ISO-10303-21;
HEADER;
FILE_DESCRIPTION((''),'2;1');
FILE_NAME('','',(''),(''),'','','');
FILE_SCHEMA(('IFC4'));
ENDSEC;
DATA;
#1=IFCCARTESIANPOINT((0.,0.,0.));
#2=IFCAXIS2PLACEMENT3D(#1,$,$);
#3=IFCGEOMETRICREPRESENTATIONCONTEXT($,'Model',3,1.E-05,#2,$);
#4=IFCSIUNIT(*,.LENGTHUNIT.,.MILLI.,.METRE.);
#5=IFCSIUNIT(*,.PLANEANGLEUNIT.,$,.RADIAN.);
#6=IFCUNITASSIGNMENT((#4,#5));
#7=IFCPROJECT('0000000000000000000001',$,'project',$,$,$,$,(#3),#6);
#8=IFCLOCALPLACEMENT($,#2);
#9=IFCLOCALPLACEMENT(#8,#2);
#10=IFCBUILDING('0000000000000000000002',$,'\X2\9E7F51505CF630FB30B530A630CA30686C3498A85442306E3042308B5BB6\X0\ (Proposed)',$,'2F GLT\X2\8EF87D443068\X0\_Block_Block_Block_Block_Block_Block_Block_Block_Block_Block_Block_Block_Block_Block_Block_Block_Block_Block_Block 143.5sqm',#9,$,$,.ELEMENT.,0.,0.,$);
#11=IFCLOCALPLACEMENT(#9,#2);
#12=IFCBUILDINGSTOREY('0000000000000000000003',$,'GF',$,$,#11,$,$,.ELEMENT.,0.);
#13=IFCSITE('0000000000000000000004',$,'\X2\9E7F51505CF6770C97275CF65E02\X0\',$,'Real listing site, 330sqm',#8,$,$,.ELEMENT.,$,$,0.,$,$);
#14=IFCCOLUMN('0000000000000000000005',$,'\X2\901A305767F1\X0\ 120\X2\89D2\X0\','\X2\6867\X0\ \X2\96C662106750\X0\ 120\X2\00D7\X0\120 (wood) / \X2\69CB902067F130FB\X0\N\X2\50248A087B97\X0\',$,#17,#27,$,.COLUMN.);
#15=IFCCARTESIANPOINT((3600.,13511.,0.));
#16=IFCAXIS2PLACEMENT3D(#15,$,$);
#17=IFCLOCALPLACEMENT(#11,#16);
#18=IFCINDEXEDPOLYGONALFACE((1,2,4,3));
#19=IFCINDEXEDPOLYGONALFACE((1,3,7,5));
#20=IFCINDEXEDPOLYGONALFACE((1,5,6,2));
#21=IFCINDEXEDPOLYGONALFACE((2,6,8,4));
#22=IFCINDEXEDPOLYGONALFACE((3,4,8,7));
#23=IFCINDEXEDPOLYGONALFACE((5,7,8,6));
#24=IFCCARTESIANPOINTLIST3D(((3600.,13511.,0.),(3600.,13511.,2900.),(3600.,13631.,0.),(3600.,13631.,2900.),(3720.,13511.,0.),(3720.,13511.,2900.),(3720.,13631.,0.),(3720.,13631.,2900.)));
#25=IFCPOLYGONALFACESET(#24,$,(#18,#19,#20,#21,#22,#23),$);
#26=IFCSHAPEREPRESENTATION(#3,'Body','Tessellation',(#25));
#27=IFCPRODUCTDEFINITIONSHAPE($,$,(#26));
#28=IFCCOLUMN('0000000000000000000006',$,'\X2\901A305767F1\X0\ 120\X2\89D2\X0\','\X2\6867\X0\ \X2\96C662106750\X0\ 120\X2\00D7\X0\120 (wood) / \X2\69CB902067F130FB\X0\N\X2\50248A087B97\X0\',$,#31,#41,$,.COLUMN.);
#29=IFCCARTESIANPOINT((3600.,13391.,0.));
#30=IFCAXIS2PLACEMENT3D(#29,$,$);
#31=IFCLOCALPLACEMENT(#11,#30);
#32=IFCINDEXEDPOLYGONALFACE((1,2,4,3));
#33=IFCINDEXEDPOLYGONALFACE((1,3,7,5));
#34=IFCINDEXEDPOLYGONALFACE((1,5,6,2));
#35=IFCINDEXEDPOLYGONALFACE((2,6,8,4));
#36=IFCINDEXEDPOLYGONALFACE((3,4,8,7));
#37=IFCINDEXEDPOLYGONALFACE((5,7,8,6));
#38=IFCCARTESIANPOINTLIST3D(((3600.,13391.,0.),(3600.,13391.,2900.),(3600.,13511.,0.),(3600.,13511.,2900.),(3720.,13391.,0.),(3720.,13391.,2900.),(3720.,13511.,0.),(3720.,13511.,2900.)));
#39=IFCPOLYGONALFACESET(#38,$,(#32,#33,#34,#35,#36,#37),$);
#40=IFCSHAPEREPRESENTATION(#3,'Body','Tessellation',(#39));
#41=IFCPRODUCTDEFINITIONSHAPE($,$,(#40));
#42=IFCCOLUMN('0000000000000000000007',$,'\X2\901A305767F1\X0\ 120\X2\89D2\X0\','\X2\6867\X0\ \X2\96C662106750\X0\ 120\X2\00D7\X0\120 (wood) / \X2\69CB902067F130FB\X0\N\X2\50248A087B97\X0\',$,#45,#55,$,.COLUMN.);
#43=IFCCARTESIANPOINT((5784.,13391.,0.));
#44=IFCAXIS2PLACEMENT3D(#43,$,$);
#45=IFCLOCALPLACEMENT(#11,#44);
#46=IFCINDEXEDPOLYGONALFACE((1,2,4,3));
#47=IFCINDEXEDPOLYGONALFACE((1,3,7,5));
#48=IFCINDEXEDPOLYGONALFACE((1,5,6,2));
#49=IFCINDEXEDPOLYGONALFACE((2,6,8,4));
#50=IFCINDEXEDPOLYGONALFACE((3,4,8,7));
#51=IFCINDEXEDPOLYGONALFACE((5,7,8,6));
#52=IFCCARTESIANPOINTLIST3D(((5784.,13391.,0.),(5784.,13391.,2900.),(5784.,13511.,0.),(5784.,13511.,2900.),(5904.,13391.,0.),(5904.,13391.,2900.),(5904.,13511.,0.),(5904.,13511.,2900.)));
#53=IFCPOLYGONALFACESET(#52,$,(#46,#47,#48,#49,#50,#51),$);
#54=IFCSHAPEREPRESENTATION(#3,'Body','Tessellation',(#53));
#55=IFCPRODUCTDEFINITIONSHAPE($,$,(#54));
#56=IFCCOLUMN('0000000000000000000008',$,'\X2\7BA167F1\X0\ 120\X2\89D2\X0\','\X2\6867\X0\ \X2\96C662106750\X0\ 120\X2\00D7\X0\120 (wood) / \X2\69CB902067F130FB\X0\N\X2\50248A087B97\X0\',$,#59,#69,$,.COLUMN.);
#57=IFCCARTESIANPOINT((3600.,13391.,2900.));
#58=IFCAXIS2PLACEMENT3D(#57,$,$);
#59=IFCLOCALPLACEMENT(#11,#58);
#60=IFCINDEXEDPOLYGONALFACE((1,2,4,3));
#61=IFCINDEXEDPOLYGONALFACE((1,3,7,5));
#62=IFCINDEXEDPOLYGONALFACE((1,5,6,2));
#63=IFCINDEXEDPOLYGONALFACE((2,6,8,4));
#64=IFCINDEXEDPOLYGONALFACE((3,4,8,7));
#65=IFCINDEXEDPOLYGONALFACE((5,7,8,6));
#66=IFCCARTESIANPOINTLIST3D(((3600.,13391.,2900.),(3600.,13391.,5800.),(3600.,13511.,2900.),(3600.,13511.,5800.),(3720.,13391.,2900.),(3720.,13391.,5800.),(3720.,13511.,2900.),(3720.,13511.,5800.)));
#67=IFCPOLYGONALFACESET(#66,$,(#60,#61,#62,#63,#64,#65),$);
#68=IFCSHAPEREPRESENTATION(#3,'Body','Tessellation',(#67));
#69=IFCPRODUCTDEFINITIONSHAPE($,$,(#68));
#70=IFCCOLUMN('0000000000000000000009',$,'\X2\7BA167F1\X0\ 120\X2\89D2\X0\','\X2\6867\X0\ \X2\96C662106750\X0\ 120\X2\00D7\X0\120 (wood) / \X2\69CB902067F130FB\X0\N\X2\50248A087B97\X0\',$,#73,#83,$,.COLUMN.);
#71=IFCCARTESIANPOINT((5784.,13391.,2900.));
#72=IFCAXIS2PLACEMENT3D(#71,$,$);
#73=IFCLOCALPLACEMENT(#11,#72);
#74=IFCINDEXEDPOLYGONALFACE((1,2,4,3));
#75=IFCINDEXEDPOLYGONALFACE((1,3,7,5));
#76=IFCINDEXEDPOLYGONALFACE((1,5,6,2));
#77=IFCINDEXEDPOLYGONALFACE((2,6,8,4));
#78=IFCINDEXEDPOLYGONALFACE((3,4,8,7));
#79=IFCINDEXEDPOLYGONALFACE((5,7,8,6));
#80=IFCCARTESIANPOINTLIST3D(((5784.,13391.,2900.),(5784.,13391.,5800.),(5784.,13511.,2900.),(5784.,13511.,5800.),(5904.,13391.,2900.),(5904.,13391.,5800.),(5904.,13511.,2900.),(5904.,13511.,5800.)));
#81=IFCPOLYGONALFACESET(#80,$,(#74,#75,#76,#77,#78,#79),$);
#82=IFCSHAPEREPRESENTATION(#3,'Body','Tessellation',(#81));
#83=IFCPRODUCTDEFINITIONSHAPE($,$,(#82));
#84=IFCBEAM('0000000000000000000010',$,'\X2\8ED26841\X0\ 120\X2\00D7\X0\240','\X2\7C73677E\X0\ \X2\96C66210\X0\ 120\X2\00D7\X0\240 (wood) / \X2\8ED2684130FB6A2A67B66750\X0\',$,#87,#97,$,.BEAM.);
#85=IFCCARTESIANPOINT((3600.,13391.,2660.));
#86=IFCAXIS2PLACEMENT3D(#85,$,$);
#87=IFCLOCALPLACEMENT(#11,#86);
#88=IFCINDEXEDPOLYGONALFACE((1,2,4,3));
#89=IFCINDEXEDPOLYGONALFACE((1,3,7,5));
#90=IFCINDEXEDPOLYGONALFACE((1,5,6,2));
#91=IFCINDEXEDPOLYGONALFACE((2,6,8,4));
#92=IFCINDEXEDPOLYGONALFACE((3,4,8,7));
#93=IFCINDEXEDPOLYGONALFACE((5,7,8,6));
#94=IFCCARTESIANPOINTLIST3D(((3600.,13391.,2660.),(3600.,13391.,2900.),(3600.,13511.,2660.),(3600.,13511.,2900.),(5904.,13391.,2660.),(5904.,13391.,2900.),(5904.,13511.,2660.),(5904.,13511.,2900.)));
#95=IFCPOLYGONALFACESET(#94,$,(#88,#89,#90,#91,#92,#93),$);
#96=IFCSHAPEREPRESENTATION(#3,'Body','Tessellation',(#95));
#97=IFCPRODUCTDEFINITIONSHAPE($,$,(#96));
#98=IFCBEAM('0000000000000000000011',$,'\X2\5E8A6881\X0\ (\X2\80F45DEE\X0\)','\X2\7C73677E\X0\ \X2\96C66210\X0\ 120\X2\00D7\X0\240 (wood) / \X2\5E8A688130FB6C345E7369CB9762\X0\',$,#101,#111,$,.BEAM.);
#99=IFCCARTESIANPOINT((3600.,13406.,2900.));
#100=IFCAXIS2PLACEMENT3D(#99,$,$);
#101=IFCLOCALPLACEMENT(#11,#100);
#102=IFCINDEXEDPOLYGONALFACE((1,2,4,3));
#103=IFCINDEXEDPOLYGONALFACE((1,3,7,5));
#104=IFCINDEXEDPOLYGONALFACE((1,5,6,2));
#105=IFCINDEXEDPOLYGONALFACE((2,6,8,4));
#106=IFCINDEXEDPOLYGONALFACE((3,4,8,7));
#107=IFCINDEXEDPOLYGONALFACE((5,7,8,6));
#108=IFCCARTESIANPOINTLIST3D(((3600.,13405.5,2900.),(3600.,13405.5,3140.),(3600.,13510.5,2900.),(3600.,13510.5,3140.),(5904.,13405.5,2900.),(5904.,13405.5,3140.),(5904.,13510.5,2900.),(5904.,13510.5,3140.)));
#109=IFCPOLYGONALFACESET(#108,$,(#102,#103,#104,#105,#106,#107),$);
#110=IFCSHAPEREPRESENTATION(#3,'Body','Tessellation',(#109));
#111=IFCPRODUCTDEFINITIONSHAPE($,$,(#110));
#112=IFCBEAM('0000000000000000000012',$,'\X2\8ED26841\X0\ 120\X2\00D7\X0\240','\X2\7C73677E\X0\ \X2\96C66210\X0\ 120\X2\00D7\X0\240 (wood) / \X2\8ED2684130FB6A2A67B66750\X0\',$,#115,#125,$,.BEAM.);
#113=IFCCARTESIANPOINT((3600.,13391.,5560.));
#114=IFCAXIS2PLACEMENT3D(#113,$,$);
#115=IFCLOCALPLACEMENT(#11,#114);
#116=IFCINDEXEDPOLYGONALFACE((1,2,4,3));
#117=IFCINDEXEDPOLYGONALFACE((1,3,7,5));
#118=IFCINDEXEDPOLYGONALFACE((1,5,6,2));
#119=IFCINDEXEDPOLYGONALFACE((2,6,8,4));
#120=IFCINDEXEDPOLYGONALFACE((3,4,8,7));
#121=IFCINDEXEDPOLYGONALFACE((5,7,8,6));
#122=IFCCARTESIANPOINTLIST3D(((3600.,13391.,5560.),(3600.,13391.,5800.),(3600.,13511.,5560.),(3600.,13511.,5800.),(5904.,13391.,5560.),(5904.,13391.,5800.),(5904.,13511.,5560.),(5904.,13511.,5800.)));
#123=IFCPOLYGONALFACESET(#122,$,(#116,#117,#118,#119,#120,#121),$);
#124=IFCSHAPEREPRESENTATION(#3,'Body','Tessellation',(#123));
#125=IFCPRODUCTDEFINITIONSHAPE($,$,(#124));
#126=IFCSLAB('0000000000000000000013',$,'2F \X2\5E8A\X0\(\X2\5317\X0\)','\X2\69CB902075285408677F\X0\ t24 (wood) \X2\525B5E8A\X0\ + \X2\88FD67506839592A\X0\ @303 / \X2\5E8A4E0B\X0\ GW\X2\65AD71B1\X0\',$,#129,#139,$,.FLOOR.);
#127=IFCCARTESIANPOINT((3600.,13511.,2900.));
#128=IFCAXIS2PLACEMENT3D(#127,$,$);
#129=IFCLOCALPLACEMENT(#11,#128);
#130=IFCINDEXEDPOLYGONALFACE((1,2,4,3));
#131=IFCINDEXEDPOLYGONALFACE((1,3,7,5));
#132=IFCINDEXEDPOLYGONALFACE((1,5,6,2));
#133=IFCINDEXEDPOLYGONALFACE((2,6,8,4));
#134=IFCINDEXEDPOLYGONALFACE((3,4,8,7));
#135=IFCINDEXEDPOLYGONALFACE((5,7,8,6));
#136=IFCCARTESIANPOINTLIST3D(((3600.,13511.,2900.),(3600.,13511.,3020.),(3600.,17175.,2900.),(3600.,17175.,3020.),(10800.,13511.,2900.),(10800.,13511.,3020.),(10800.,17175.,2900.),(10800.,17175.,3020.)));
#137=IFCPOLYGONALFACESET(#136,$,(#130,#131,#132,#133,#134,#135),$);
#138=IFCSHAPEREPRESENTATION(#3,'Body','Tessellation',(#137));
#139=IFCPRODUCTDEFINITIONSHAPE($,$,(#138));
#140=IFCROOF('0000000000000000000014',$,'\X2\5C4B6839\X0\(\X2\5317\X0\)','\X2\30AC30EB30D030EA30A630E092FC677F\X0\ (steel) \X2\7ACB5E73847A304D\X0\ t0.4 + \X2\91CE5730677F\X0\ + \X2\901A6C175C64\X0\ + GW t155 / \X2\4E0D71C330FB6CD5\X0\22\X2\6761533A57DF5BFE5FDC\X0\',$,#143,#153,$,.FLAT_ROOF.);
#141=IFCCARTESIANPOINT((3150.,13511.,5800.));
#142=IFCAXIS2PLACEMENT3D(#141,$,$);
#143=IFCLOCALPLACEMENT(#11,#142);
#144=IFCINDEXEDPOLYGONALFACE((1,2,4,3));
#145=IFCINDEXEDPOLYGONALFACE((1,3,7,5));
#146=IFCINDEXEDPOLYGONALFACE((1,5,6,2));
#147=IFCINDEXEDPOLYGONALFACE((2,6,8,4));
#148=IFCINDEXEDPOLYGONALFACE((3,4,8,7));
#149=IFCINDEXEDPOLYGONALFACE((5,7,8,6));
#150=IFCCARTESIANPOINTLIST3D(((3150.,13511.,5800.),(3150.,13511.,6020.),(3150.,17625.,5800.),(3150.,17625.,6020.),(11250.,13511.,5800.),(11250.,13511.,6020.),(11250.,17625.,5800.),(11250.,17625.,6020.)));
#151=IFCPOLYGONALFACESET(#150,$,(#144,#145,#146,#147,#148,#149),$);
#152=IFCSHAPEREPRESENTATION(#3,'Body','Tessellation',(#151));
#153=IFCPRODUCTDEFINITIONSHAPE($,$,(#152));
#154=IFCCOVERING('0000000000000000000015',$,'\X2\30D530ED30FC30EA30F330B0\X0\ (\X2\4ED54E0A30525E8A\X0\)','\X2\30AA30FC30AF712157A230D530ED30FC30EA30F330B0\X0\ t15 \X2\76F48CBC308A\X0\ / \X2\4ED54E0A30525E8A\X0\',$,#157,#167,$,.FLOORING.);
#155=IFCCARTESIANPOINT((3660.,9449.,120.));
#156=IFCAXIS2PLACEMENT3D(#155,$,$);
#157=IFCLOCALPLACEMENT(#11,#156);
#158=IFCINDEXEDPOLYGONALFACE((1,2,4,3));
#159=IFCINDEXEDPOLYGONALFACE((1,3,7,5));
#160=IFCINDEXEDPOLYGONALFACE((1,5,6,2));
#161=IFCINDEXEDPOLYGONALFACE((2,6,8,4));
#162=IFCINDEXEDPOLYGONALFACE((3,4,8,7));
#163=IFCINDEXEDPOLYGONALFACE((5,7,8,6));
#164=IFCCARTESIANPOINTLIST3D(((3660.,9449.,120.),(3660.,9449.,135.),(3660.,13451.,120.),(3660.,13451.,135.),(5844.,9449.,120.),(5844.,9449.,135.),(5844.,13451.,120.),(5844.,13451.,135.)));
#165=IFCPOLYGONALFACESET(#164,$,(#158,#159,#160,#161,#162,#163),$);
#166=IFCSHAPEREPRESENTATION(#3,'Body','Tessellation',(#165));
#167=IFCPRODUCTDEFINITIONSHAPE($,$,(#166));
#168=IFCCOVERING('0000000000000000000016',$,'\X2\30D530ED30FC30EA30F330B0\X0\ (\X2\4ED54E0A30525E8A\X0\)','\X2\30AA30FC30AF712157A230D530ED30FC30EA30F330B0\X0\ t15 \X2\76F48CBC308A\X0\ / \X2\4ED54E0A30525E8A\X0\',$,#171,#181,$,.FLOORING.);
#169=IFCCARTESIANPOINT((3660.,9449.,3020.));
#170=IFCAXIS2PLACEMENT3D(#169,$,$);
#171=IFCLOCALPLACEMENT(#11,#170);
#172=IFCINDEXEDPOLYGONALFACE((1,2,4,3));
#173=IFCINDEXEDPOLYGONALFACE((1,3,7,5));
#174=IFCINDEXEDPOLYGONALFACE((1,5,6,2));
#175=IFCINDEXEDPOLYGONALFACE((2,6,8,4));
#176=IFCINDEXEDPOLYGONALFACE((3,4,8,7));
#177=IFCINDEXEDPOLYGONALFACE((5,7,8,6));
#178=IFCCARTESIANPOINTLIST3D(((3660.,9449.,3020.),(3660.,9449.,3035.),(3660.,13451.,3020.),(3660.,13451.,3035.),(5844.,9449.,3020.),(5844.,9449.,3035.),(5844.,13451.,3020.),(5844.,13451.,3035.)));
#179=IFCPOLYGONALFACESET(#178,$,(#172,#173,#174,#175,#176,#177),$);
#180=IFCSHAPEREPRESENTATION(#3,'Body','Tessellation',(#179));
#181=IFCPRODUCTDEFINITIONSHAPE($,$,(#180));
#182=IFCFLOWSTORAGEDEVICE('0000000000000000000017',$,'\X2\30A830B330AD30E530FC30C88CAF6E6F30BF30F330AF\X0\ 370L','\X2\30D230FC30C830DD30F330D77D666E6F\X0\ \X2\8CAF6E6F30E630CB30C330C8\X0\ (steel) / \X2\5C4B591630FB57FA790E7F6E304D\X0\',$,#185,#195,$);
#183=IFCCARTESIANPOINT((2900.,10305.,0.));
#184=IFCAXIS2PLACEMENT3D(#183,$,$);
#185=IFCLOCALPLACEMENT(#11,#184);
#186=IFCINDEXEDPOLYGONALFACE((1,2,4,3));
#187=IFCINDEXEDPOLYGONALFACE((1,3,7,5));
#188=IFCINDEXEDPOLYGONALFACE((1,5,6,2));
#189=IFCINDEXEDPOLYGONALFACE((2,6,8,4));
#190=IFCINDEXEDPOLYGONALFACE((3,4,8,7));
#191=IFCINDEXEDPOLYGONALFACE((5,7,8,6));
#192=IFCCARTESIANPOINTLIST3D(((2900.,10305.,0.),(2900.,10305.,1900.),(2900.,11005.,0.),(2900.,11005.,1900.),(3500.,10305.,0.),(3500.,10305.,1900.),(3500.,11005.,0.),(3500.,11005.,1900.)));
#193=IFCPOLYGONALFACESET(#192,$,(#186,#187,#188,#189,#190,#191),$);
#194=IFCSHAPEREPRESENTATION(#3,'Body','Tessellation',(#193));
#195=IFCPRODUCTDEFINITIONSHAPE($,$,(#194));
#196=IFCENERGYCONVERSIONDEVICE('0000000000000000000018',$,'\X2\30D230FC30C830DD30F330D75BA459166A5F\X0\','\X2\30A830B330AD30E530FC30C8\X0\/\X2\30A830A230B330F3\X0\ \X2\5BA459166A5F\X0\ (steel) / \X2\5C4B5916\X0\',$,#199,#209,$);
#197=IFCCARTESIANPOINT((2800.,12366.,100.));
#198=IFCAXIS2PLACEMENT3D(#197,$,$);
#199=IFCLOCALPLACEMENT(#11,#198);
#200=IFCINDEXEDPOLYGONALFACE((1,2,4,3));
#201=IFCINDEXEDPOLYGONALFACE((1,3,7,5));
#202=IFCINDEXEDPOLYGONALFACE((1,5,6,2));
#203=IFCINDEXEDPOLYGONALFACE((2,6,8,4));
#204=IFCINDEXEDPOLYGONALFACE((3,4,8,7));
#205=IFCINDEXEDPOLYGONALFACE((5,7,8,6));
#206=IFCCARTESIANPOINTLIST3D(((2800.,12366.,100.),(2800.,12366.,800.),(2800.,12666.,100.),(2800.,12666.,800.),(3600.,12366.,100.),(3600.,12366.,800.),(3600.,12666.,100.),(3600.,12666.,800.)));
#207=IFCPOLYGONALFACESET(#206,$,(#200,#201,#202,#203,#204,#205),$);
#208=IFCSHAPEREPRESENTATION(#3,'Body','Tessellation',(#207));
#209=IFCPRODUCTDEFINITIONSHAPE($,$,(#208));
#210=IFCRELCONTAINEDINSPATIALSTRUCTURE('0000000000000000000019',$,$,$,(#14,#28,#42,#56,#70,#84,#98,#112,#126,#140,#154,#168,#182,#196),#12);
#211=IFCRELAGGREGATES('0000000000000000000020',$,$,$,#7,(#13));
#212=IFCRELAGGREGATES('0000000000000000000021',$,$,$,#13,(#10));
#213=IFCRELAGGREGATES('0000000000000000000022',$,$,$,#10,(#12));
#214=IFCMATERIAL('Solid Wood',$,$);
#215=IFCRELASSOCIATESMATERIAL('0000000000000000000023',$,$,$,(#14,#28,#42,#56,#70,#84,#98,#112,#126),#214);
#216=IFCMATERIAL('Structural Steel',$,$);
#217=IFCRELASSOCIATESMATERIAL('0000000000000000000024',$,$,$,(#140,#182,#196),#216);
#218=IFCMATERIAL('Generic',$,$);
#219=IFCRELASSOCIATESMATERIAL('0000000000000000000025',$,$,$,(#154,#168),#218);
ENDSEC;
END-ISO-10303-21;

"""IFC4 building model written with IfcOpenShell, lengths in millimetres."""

from ifc_helpers import new_model, si_unit, frame, frame_2d, origin, place, context, project, spatial, rectangle, extrude, material, element, save


model = new_model("IFC4")

# Units and contexts
model_context = context("Model", 3, precision=1e-05, world=origin())
ifc_project = project(units=[si_unit("LENGTHUNIT", "METRE", prefix="MILLI"), si_unit("PLANEANGLEUNIT", "RADIAN")], contexts=[model_context])

# Site, building, storey
site_placement = place(None, origin())
site = spatial("IfcSite", under=ifc_project, at=site_placement, Name="鹿児島県霧島市", ObjectType="Real listing site, 330sqm", CompositionType="ELEMENT", RefElevation=0.0)
building_placement = place(site_placement, origin())
building = spatial("IfcBuilding", under=site, at=building_placement, Name="鹿児島・サウナと水風呂のある家 (Proposed)", ObjectType="2F GLT軸組と_Block_Block_Block_Block_Block_Block_Block_Block_Block_Block_Block_Block_Block_Block_Block_Block_Block_Block_Block 143.5sqm", CompositionType="ELEMENT", ElevationOfRefHeight=0.0, ElevationOfTerrain=0.0)
storey_placement = place(building_placement, origin())
storey = spatial("IfcBuildingStorey", under=building, at=storey_placement, Name="GF", CompositionType="ELEMENT", Elevation=0.0)

# Columns
ifc_material_1 = material(Name="Solid Wood")
column_1_placement = place(storey_placement, frame((3600.0, 13511.0, 0.0)))
element("IfcColumn", 1, at=column_1_placement, inside=storey, material=ifc_material_1, Name="通し柱 120角", Description="桧 集成材 120×120 (wood) / 構造柱・N値計算", PredefinedType="COLUMN", context=model_context, shape_type="SweptSolid", body=[
    extrude(rectangle(XDim=120.0, YDim=120.0, at=frame_2d((60.0, 60.0))), frame((3600.0, 13511.0, 0.0)), (0.0, 0.0, 1.0), 2900.0),
])
column_2_placement = place(storey_placement, frame((3600.0, 13391.0, 0.0)))
element("IfcColumn", 2, at=column_2_placement, inside=storey, material=ifc_material_1, Name="通し柱 120角", Description="桧 集成材 120×120 (wood) / 構造柱・N値計算", PredefinedType="COLUMN", context=model_context, shape_type="SweptSolid", body=[
    extrude(rectangle(XDim=120.0, YDim=120.0, at=frame_2d((60.0, 60.0))), frame((3600.0, 13391.0, 0.0)), (0.0, 0.0, 1.0), 2900.0),
])
column_3_placement = place(storey_placement, frame((5784.0, 13391.0, 0.0)))
element("IfcColumn", 3, at=column_3_placement, inside=storey, material=ifc_material_1, Name="通し柱 120角", Description="桧 集成材 120×120 (wood) / 構造柱・N値計算", PredefinedType="COLUMN", context=model_context, shape_type="SweptSolid", body=[
    extrude(rectangle(XDim=120.0, YDim=120.0, at=frame_2d((60.0, 60.0))), frame((5784.0, 13391.0, 0.0)), (0.0, 0.0, 1.0), 2900.0),
])
column_4_placement = place(storey_placement, frame((3600.0, 13391.0, 2900.0)))
element("IfcColumn", 4, at=column_4_placement, inside=storey, material=ifc_material_1, Name="管柱 120角", Description="桧 集成材 120×120 (wood) / 構造柱・N値計算", PredefinedType="COLUMN", context=model_context, shape_type="SweptSolid", body=[
    extrude(rectangle(XDim=120.0, YDim=120.0, at=frame_2d((60.0, 60.0))), frame((3600.0, 13391.0, 2900.0)), (0.0, 0.0, 1.0), 2900.0),
])
column_5_placement = place(storey_placement, frame((5784.0, 13391.0, 2900.0)))
element("IfcColumn", 5, at=column_5_placement, inside=storey, material=ifc_material_1, Name="管柱 120角", Description="桧 集成材 120×120 (wood) / 構造柱・N値計算", PredefinedType="COLUMN", context=model_context, shape_type="SweptSolid", body=[
    extrude(rectangle(XDim=120.0, YDim=120.0, at=frame_2d((60.0, 60.0))), frame((5784.0, 13391.0, 2900.0)), (0.0, 0.0, 1.0), 2900.0),
])

# Beams
beam_1_placement = place(storey_placement, frame((3600.0, 13391.0, 2660.0)))
element("IfcBeam", 6, at=beam_1_placement, inside=storey, material=ifc_material_1, Name="軒桁 120×240", Description="米松 集成 120×240 (wood) / 軒桁・横架材", PredefinedType="BEAM", context=model_context, shape_type="SweptSolid", body=[
    extrude(rectangle(XDim=2304.0, YDim=120.0, at=frame_2d((1152.0, 60.0))), frame((3600.0, 13391.0, 2660.0)), (0.0, 0.0, 1.0), 240.0),
])
beam_2_placement = place(storey_placement, frame((3600.0, 13406.0, 2900.0)))
element("IfcBeam", 7, at=beam_2_placement, inside=storey, material=ifc_material_1, Name="床梁 (胴差)", Description="米松 集成 120×240 (wood) / 床梁・水平構面", PredefinedType="BEAM", context=model_context, shape_type="SweptSolid", body=[
    extrude(rectangle(XDim=2304.0, YDim=105.0, at=frame_2d((1152.0, 52.0))), frame((3600.0, 13406.0, 2900.0)), (0.0, 0.0, 1.0), 240.0),
])
beam_3_placement = place(storey_placement, frame((3600.0, 13391.0, 5560.0)))
element("IfcBeam", 8, at=beam_3_placement, inside=storey, material=ifc_material_1, Name="軒桁 120×240", Description="米松 集成 120×240 (wood) / 軒桁・横架材", PredefinedType="BEAM", context=model_context, shape_type="SweptSolid", body=[
    extrude(rectangle(XDim=2304.0, YDim=120.0, at=frame_2d((1152.0, 60.0))), frame((3600.0, 13391.0, 5560.0)), (0.0, 0.0, 1.0), 240.0),
])

# Slab
slab_1_placement = place(storey_placement, frame((3600.0, 13511.0, 2900.0)))
element("IfcSlab", 9, at=slab_1_placement, inside=storey, material=ifc_material_1, Name="2F 床(北)", Description="構造用合板 t24 (wood) 剛床 + 製材根太 @303 / 床下 GW断熱", PredefinedType="FLOOR", context=model_context, shape_type="SweptSolid", body=[
    extrude(rectangle(XDim=7200.0, YDim=3664.0, at=frame_2d((3600.0, 1832.0))), frame((3600.0, 13511.0, 2900.0)), (0.0, 0.0, 1.0), 120.0),
])

# Roof
ifc_material_2 = material(Name="Structural Steel")
for number, where, name in (
    (10, (3150.0, 13511.0, 5800.0), "屋根(北)"),
):
    element("IfcRoof", number, at=place(storey_placement, frame(where)), inside=storey, material=ifc_material_2, Name=name, Description="ガルバリウム鋼板 (steel) 立平葺き t0.4 + 野地板 + 通気層 + GW t155 / 不燃・法22条区域対応", PredefinedType="FLAT_ROOF", context=model_context, shape_type="SweptSolid", body=[
        extrude(rectangle(XDim=8100.0, YDim=4114.0, at=frame_2d((4050.0, 2057.0))), frame((3150.0, 13511.0, 5800.0)), (0.0, 0.0, 1.0), 220.0),
    ])

# Coverings
ifc_material_3 = material(Name="Generic")
covering_1_placement = place(storey_placement, frame((3660.0, 9449.0, 120.0)))
element("IfcCovering", 11, at=covering_1_placement, inside=storey, material=ifc_material_3, Name="フローリング (仕上げ床)", Description="オーク無垢フローリング t15 直貼り / 仕上げ床", PredefinedType="FLOORING", context=model_context, shape_type="SweptSolid", body=[
    extrude(rectangle(XDim=2184.0, YDim=4002.0, at=frame_2d((1092.0, 2001.0))), frame((3660.0, 9449.0, 120.0)), (0.0, 0.0, 1.0), 15.0),
])
covering_2_placement = place(storey_placement, frame((3660.0, 9449.0, 3020.0)))
element("IfcCovering", 12, at=covering_2_placement, inside=storey, material=ifc_material_3, Name="フローリング (仕上げ床)", Description="オーク無垢フローリング t15 直貼り / 仕上げ床", PredefinedType="FLOORING", context=model_context, shape_type="SweptSolid", body=[
    extrude(rectangle(XDim=2184.0, YDim=4002.0, at=frame_2d((1092.0, 2001.0))), frame((3660.0, 9449.0, 3020.0)), (0.0, 0.0, 1.0), 15.0),
])

# Flow storage device
flow_storage_device_placement = place(storey_placement, frame((2900.0, 10305.0, 0.0)))
element("IfcFlowStorageDevice", 13, at=flow_storage_device_placement, inside=storey, material=ifc_material_2, Name="エコキュート貯湯タンク 370L", Description="ヒートポンプ給湯 貯湯ユニット (steel) / 屋外・基礎置き", context=model_context, shape_type="SweptSolid", body=[
    extrude(rectangle(XDim=600.0, YDim=700.0, at=frame_2d((300.0, 350.0))), frame((2900.0, 10305.0, 0.0)), (0.0, 0.0, 1.0), 1900.0),
])

# Energy conversion device
energy_conversion_device_placement = place(storey_placement, frame((2800.0, 12366.0, 100.0)))
element("IfcEnergyConversionDevice", 14, at=energy_conversion_device_placement, inside=storey, material=ifc_material_2, Name="ヒートポンプ室外機", Description="エコキュート/エアコン 室外機 (steel) / 屋外", context=model_context, shape_type="SweptSolid", body=[
    extrude(rectangle(XDim=800.0, YDim=300.0, at=frame_2d((400.0, 150.0))), frame((2800.0, 12366.0, 100.0)), (0.0, 0.0, 1.0), 700.0),
])

save(model, "model.ifc")
